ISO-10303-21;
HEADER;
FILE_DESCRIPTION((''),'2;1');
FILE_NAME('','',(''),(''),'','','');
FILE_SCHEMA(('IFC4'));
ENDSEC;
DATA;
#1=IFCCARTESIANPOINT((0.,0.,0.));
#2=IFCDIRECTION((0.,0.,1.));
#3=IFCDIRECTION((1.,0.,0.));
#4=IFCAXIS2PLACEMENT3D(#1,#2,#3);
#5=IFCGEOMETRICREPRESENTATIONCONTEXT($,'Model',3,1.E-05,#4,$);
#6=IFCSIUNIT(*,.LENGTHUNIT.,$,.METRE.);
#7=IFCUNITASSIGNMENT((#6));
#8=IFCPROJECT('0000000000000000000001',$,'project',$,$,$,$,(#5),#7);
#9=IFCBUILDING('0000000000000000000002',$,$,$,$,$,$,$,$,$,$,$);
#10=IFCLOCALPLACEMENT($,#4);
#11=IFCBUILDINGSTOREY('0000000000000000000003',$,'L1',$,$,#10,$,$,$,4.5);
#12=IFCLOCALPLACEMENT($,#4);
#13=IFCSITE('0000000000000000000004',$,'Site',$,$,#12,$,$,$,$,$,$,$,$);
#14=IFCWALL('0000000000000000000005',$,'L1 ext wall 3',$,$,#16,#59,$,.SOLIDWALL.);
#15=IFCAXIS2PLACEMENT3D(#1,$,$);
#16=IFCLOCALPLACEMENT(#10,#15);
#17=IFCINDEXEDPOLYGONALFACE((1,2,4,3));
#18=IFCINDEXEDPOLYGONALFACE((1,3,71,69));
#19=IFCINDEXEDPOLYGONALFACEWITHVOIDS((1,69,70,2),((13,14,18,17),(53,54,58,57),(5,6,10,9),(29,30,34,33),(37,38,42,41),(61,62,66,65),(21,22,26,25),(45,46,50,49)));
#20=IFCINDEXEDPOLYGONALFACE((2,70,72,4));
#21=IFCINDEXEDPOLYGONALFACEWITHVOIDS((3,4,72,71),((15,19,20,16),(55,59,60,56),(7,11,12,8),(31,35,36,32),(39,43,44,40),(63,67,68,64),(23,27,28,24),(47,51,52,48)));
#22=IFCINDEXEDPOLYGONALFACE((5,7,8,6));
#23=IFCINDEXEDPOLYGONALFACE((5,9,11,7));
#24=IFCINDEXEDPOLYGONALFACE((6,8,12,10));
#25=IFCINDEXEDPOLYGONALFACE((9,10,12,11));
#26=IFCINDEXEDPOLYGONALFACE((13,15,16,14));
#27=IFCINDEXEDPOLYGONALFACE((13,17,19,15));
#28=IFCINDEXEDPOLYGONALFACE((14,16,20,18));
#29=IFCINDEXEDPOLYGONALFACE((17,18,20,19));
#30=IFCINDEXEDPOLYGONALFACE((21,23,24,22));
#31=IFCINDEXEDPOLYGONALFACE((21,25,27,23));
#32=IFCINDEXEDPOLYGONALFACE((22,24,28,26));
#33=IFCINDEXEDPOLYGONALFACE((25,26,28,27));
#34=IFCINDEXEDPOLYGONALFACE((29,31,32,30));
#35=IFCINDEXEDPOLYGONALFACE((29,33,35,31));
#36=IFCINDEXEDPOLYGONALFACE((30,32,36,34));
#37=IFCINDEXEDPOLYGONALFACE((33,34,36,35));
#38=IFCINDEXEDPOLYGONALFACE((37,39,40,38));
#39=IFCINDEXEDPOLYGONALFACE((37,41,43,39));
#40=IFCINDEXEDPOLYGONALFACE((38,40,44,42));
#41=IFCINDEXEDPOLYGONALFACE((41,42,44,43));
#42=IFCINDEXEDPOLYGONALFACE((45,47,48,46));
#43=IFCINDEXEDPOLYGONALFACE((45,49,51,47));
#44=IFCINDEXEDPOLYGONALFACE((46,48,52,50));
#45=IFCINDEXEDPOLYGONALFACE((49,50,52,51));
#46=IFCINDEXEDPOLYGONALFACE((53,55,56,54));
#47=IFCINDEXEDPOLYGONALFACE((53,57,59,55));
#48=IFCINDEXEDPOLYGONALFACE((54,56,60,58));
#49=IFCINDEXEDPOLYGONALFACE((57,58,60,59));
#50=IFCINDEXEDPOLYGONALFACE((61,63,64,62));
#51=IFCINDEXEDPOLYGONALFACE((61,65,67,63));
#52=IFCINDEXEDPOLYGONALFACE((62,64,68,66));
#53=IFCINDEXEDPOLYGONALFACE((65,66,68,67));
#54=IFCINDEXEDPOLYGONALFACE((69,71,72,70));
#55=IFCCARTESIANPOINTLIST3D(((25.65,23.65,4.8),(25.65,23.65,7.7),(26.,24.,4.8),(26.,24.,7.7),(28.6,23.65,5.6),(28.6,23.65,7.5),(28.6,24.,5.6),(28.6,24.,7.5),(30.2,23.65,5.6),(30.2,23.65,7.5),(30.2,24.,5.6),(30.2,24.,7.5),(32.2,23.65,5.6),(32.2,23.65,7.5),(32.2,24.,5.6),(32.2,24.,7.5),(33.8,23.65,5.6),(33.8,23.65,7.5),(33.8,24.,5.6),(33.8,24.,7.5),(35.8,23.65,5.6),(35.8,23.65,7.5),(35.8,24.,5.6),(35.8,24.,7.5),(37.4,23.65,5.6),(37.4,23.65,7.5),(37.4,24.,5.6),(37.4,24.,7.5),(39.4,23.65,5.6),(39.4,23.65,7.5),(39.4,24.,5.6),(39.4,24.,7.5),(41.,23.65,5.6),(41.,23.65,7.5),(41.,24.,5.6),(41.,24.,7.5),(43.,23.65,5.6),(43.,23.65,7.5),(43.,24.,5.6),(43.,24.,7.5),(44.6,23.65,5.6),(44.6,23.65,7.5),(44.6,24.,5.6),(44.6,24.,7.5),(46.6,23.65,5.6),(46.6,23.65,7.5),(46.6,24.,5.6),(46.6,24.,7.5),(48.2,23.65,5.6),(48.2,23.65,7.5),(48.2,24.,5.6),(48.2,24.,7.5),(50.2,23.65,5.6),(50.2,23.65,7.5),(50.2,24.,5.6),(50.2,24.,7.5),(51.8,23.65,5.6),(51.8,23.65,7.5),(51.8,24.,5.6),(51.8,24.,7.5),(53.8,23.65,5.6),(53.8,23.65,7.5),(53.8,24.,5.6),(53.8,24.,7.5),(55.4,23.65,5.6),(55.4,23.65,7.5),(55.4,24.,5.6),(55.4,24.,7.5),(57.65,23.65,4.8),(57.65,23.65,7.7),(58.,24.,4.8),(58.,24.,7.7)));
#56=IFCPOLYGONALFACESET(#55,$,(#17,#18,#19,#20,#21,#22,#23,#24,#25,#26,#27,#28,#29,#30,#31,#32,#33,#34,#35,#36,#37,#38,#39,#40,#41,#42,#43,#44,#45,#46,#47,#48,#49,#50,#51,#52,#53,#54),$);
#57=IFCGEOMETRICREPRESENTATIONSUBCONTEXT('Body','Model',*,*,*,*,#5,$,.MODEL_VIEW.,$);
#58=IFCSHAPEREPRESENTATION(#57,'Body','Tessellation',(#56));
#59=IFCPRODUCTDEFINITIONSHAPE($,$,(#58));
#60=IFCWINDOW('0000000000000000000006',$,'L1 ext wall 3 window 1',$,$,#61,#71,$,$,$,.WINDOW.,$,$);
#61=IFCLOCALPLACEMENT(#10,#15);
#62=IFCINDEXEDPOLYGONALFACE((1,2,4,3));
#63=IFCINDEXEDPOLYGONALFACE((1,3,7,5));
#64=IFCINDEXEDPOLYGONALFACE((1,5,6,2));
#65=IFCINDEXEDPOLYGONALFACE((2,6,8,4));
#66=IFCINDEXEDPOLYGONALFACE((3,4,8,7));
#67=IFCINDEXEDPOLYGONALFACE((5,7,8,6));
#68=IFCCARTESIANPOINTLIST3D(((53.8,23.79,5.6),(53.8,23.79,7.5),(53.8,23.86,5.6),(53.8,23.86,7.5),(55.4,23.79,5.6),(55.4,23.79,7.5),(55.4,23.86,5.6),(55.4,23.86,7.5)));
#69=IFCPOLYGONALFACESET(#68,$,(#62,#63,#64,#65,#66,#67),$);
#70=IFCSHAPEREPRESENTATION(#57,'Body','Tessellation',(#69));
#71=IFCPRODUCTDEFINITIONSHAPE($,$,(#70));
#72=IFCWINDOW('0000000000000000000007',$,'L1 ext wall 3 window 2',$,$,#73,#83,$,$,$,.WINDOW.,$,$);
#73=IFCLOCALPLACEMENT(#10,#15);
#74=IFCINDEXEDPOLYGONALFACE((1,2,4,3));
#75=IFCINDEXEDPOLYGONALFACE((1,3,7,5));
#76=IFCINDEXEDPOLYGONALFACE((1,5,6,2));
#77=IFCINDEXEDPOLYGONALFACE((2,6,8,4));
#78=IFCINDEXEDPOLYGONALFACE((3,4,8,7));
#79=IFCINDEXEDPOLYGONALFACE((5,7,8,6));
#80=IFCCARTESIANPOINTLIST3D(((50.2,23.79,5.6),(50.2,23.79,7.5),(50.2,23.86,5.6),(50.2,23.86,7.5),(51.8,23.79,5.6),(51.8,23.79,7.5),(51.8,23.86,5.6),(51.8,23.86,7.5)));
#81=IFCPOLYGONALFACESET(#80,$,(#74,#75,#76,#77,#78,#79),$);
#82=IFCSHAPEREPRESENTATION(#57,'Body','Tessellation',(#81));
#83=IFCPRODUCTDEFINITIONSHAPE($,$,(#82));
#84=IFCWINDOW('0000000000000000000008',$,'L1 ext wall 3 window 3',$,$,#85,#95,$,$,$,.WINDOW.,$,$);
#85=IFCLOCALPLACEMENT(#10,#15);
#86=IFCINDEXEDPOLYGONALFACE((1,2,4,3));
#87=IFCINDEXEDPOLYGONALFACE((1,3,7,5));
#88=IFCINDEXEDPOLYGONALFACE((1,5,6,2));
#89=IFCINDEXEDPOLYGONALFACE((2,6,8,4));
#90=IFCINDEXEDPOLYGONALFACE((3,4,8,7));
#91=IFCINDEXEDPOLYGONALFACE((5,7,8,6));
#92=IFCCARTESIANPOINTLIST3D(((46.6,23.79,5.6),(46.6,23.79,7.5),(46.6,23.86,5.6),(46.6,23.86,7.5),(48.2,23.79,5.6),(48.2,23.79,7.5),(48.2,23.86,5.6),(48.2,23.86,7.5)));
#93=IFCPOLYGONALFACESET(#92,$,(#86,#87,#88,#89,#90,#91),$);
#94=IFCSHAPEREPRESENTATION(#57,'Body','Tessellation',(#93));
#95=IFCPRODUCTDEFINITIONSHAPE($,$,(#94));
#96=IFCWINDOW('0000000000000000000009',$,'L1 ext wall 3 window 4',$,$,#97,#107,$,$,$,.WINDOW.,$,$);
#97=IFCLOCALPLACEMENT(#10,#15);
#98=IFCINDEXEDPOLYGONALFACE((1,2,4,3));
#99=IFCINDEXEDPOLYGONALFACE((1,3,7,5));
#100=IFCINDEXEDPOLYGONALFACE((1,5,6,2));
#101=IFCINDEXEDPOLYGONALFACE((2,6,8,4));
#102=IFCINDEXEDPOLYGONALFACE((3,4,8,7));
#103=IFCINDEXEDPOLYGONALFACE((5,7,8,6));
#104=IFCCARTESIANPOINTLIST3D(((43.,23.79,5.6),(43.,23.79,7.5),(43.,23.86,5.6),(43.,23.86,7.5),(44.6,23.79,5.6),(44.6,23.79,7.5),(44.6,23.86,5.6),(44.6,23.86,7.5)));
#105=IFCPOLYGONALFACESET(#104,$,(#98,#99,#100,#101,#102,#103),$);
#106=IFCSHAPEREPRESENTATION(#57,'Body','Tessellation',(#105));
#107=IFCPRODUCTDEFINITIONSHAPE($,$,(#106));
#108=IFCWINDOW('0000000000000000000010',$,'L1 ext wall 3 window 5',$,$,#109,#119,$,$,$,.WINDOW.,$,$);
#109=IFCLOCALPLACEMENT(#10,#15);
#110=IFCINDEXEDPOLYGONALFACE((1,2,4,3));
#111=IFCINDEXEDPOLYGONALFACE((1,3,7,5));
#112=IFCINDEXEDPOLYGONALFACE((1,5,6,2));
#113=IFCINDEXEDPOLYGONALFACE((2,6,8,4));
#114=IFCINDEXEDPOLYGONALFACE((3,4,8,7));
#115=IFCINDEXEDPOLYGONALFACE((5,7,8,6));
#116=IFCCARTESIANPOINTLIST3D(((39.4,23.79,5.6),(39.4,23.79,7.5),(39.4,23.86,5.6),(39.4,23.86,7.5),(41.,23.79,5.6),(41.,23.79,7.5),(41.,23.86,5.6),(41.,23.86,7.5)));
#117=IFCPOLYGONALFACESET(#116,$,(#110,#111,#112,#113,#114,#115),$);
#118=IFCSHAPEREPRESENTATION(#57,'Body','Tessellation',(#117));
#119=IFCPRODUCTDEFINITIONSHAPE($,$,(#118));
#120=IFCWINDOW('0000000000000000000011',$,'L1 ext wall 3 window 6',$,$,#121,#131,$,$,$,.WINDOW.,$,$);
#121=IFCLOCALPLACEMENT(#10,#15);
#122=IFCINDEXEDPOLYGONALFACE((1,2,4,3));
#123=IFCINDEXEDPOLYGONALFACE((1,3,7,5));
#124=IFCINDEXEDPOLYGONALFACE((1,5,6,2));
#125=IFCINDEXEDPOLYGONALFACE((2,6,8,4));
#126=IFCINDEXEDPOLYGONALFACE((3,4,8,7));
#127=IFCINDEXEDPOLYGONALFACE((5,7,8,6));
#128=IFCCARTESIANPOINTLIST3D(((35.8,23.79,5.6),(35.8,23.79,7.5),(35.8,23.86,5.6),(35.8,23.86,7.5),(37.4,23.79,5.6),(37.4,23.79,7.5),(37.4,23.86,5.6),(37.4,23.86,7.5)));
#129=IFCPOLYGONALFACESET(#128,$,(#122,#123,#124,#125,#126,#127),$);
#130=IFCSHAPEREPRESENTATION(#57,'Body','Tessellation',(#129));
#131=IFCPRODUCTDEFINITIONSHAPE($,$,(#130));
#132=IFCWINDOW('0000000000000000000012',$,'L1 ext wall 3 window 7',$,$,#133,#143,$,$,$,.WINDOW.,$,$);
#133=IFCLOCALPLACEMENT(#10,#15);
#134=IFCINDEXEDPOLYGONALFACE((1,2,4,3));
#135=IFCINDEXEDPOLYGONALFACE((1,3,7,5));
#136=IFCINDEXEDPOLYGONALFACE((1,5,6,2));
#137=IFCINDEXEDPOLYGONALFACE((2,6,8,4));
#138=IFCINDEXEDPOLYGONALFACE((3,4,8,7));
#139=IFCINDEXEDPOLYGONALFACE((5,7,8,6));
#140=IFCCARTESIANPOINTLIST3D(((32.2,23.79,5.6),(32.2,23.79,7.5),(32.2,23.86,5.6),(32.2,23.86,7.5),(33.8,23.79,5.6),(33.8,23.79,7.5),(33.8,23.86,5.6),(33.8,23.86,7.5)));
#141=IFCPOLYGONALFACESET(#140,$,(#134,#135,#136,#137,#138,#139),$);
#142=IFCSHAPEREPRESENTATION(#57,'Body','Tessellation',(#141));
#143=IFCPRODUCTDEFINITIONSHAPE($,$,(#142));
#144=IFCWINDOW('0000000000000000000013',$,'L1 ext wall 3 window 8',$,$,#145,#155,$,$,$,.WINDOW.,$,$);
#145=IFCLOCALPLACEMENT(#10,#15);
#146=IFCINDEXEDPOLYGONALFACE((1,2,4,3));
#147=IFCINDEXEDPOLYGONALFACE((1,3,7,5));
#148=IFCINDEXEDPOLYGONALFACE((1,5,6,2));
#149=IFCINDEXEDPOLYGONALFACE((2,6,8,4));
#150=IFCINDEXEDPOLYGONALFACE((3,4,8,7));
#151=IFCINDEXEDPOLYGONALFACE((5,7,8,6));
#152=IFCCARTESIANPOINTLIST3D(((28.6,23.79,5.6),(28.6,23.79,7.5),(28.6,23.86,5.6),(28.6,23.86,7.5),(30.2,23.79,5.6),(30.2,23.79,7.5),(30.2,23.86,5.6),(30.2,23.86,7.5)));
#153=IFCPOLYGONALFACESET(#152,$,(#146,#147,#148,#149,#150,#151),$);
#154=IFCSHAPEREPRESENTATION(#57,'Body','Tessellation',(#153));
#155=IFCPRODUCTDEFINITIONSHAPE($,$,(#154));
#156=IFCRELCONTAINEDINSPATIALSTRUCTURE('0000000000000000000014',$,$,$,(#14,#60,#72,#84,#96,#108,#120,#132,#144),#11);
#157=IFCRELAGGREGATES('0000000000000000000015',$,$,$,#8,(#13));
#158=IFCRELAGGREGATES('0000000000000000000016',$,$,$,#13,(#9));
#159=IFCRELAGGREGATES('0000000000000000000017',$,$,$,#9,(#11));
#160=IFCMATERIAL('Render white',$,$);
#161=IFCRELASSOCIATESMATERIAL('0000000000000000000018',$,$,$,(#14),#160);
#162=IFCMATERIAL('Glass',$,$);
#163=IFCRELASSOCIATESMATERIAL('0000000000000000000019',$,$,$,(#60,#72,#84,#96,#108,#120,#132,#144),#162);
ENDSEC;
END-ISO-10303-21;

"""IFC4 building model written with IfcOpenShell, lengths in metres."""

from ifc_helpers import new_model, si_unit, frame, origin_with_axes, place, context, subcontext, project, spatial, polyline, outline, extrude, material, element, fill, save


model = new_model("IFC4")

# Units and contexts
model_context = context("Model", 3, precision=1e-05, world=origin_with_axes())
body_context = subcontext(model_context, "Body", "Model", "MODEL_VIEW")
ifc_project = project(units=[si_unit("LENGTHUNIT", "METRE")], contexts=[model_context])

# Site, building, storey
site_placement = place(None, origin_with_axes())
site = spatial("IfcSite", under=ifc_project, at=site_placement, Name="Site")
building = spatial("IfcBuilding", under=site)
storey_placement = place(None, origin_with_axes())
storey = spatial("IfcBuildingStorey", under=building, at=storey_placement, Name="L1", Elevation=4.5)

# Wall, openings, windows
ifc_material_1 = material(Name="Render white")
wall_1_placement = place(storey_placement, origin_with_axes())
wall_1 = element("IfcWall", 1, at=wall_1_placement, inside=storey, material=ifc_material_1, Name="L1 ext wall 3", PredefinedType="SOLIDWALL", context=body_context, shape_type="SweptSolid", body=[
    extrude(outline(polyline([(58.0, 24.0), (26.0, 24.0), (25.65, 23.65), (57.65, 23.65), (58.0, 24.0)])), frame((0.0, 0.0, 4.8), z_axis=(0.0, 0.0, 1.0), x_axis=(1.0, 0.0, 0.0)), (0.0, 0.0, 1.0), 2.9),
])
opening_1_placement = place(wall_1_placement, origin_with_axes())
opening_1 = element("IfcOpeningElement", 2, at=opening_1_placement, cuts=wall_1, context=body_context, shape_type="SweptSolid", body=[
    extrude(outline(polyline([(55.4, 24.05), (53.8, 24.05), (53.8, 23.6), (55.4, 23.6), (55.4, 24.05)])), frame((0.0, 0.0, 5.6), z_axis=(0.0, 0.0, 1.0), x_axis=(1.0, 0.0, 0.0)), (0.0, 0.0, 1.0), 1.9),
])
opening_2_placement = place(wall_1_placement, origin_with_axes())
opening_2 = element("IfcOpeningElement", 3, at=opening_2_placement, cuts=wall_1, context=body_context, shape_type="SweptSolid", body=[
    extrude(outline(polyline([(51.8, 24.05), (50.2, 24.05), (50.2, 23.6), (51.8, 23.6), (51.8, 24.05)])), frame((0.0, 0.0, 5.6), z_axis=(0.0, 0.0, 1.0), x_axis=(1.0, 0.0, 0.0)), (0.0, 0.0, 1.0), 1.9),
])
opening_3_placement = place(wall_1_placement, origin_with_axes())
opening_3 = element("IfcOpeningElement", 4, at=opening_3_placement, cuts=wall_1, context=body_context, shape_type="SweptSolid", body=[
    extrude(outline(polyline([(48.2, 24.05), (46.6, 24.05), (46.6, 23.6), (48.2, 23.6), (48.2, 24.05)])), frame((0.0, 0.0, 5.6), z_axis=(0.0, 0.0, 1.0), x_axis=(1.0, 0.0, 0.0)), (0.0, 0.0, 1.0), 1.9),
])
opening_4_placement = place(wall_1_placement, origin_with_axes())
opening_4 = element("IfcOpeningElement", 5, at=opening_4_placement, cuts=wall_1, context=body_context, shape_type="SweptSolid", body=[
    extrude(outline(polyline([(44.6, 24.05), (43.0, 24.05), (43.0, 23.6), (44.6, 23.6), (44.6, 24.05)])), frame((0.0, 0.0, 5.6), z_axis=(0.0, 0.0, 1.0), x_axis=(1.0, 0.0, 0.0)), (0.0, 0.0, 1.0), 1.9),
])
opening_5_placement = place(wall_1_placement, origin_with_axes())
opening_5 = element("IfcOpeningElement", 6, at=opening_5_placement, cuts=wall_1, context=body_context, shape_type="SweptSolid", body=[
    extrude(outline(polyline([(41.0, 24.05), (39.4, 24.05), (39.4, 23.6), (41.0, 23.6), (41.0, 24.05)])), frame((0.0, 0.0, 5.6), z_axis=(0.0, 0.0, 1.0), x_axis=(1.0, 0.0, 0.0)), (0.0, 0.0, 1.0), 1.9),
])
opening_6_placement = place(wall_1_placement, origin_with_axes())
opening_6 = element("IfcOpeningElement", 7, at=opening_6_placement, cuts=wall_1, context=body_context, shape_type="SweptSolid", body=[
    extrude(outline(polyline([(37.4, 24.05), (35.8, 24.05), (35.8, 23.6), (37.4, 23.6), (37.4, 24.05)])), frame((0.0, 0.0, 5.6), z_axis=(0.0, 0.0, 1.0), x_axis=(1.0, 0.0, 0.0)), (0.0, 0.0, 1.0), 1.9),
])
opening_7_placement = place(wall_1_placement, origin_with_axes())
opening_7 = element("IfcOpeningElement", 8, at=opening_7_placement, cuts=wall_1, context=body_context, shape_type="SweptSolid", body=[
    extrude(outline(polyline([(33.8, 24.05), (32.2, 24.05), (32.2, 23.6), (33.8, 23.6), (33.8, 24.05)])), frame((0.0, 0.0, 5.6), z_axis=(0.0, 0.0, 1.0), x_axis=(1.0, 0.0, 0.0)), (0.0, 0.0, 1.0), 1.9),
])
opening_8_placement = place(wall_1_placement, origin_with_axes())
opening_8 = element("IfcOpeningElement", 9, at=opening_8_placement, cuts=wall_1, context=body_context, shape_type="SweptSolid", body=[
    extrude(outline(polyline([(30.2, 24.05), (28.6, 24.05), (28.6, 23.6), (30.2, 23.6), (30.2, 24.05)])), frame((0.0, 0.0, 5.6), z_axis=(0.0, 0.0, 1.0), x_axis=(1.0, 0.0, 0.0)), (0.0, 0.0, 1.0), 1.9),
])
ifc_material_2 = material(Name="Glass")
window_1_placement = place(storey_placement, origin_with_axes())
window_1 = element("IfcWindow", 10, at=window_1_placement, inside=storey, material=ifc_material_2, Name="L1 ext wall 3 window 1", PredefinedType="WINDOW", context=body_context, shape_type="SweptSolid", body=[
    extrude(outline(polyline([(55.4, 23.86), (53.8, 23.86), (53.8, 23.79), (55.4, 23.79), (55.4, 23.86)])), frame((0.0, 0.0, 5.6), z_axis=(0.0, 0.0, 1.0), x_axis=(1.0, 0.0, 0.0)), (0.0, 0.0, 1.0), 1.9),
])
fill(opening_1, window_1)
window_2_placement = place(storey_placement, origin_with_axes())
window_2 = element("IfcWindow", 11, at=window_2_placement, inside=storey, material=ifc_material_2, Name="L1 ext wall 3 window 2", PredefinedType="WINDOW", context=body_context, shape_type="SweptSolid", body=[
    extrude(outline(polyline([(51.8, 23.86), (50.2, 23.86), (50.2, 23.79), (51.8, 23.79), (51.8, 23.86)])), frame((0.0, 0.0, 5.6), z_axis=(0.0, 0.0, 1.0), x_axis=(1.0, 0.0, 0.0)), (0.0, 0.0, 1.0), 1.9),
])
fill(opening_2, window_2)
window_3_placement = place(storey_placement, origin_with_axes())
window_3 = element("IfcWindow", 12, at=window_3_placement, inside=storey, material=ifc_material_2, Name="L1 ext wall 3 window 3", PredefinedType="WINDOW", context=body_context, shape_type="SweptSolid", body=[
    extrude(outline(polyline([(48.2, 23.86), (46.6, 23.86), (46.6, 23.79), (48.2, 23.79), (48.2, 23.86)])), frame((0.0, 0.0, 5.6), z_axis=(0.0, 0.0, 1.0), x_axis=(1.0, 0.0, 0.0)), (0.0, 0.0, 1.0), 1.9),
])
fill(opening_3, window_3)
window_4_placement = place(storey_placement, origin_with_axes())
window_4 = element("IfcWindow", 13, at=window_4_placement, inside=storey, material=ifc_material_2, Name="L1 ext wall 3 window 4", PredefinedType="WINDOW", context=body_context, shape_type="SweptSolid", body=[
    extrude(outline(polyline([(44.6, 23.86), (43.0, 23.86), (43.0, 23.79), (44.6, 23.79), (44.6, 23.86)])), frame((0.0, 0.0, 5.6), z_axis=(0.0, 0.0, 1.0), x_axis=(1.0, 0.0, 0.0)), (0.0, 0.0, 1.0), 1.9),
])
fill(opening_4, window_4)
window_5_placement = place(storey_placement, origin_with_axes())
window_5 = element("IfcWindow", 14, at=window_5_placement, inside=storey, material=ifc_material_2, Name="L1 ext wall 3 window 5", PredefinedType="WINDOW", context=body_context, shape_type="SweptSolid", body=[
    extrude(outline(polyline([(41.0, 23.86), (39.4, 23.86), (39.4, 23.79), (41.0, 23.79), (41.0, 23.86)])), frame((0.0, 0.0, 5.6), z_axis=(0.0, 0.0, 1.0), x_axis=(1.0, 0.0, 0.0)), (0.0, 0.0, 1.0), 1.9),
])
fill(opening_5, window_5)
window_6_placement = place(storey_placement, origin_with_axes())
window_6 = element("IfcWindow", 15, at=window_6_placement, inside=storey, material=ifc_material_2, Name="L1 ext wall 3 window 6", PredefinedType="WINDOW", context=body_context, shape_type="SweptSolid", body=[
    extrude(outline(polyline([(37.4, 23.86), (35.8, 23.86), (35.8, 23.79), (37.4, 23.79), (37.4, 23.86)])), frame((0.0, 0.0, 5.6), z_axis=(0.0, 0.0, 1.0), x_axis=(1.0, 0.0, 0.0)), (0.0, 0.0, 1.0), 1.9),
])
fill(opening_6, window_6)
window_7_placement = place(storey_placement, origin_with_axes())
window_7 = element("IfcWindow", 16, at=window_7_placement, inside=storey, material=ifc_material_2, Name="L1 ext wall 3 window 7", PredefinedType="WINDOW", context=body_context, shape_type="SweptSolid", body=[
    extrude(outline(polyline([(33.8, 23.86), (32.2, 23.86), (32.2, 23.79), (33.8, 23.79), (33.8, 23.86)])), frame((0.0, 0.0, 5.6), z_axis=(0.0, 0.0, 1.0), x_axis=(1.0, 0.0, 0.0)), (0.0, 0.0, 1.0), 1.9),
])
fill(opening_7, window_7)
window_8_placement = place(storey_placement, origin_with_axes())
window_8 = element("IfcWindow", 17, at=window_8_placement, inside=storey, material=ifc_material_2, Name="L1 ext wall 3 window 8", PredefinedType="WINDOW", context=body_context, shape_type="SweptSolid", body=[
    extrude(outline(polyline([(30.2, 23.86), (28.6, 23.86), (28.6, 23.79), (30.2, 23.79), (30.2, 23.86)])), frame((0.0, 0.0, 5.6), z_axis=(0.0, 0.0, 1.0), x_axis=(1.0, 0.0, 0.0)), (0.0, 0.0, 1.0), 1.9),
])
fill(opening_8, window_8)

save(model, "model.ifc")
